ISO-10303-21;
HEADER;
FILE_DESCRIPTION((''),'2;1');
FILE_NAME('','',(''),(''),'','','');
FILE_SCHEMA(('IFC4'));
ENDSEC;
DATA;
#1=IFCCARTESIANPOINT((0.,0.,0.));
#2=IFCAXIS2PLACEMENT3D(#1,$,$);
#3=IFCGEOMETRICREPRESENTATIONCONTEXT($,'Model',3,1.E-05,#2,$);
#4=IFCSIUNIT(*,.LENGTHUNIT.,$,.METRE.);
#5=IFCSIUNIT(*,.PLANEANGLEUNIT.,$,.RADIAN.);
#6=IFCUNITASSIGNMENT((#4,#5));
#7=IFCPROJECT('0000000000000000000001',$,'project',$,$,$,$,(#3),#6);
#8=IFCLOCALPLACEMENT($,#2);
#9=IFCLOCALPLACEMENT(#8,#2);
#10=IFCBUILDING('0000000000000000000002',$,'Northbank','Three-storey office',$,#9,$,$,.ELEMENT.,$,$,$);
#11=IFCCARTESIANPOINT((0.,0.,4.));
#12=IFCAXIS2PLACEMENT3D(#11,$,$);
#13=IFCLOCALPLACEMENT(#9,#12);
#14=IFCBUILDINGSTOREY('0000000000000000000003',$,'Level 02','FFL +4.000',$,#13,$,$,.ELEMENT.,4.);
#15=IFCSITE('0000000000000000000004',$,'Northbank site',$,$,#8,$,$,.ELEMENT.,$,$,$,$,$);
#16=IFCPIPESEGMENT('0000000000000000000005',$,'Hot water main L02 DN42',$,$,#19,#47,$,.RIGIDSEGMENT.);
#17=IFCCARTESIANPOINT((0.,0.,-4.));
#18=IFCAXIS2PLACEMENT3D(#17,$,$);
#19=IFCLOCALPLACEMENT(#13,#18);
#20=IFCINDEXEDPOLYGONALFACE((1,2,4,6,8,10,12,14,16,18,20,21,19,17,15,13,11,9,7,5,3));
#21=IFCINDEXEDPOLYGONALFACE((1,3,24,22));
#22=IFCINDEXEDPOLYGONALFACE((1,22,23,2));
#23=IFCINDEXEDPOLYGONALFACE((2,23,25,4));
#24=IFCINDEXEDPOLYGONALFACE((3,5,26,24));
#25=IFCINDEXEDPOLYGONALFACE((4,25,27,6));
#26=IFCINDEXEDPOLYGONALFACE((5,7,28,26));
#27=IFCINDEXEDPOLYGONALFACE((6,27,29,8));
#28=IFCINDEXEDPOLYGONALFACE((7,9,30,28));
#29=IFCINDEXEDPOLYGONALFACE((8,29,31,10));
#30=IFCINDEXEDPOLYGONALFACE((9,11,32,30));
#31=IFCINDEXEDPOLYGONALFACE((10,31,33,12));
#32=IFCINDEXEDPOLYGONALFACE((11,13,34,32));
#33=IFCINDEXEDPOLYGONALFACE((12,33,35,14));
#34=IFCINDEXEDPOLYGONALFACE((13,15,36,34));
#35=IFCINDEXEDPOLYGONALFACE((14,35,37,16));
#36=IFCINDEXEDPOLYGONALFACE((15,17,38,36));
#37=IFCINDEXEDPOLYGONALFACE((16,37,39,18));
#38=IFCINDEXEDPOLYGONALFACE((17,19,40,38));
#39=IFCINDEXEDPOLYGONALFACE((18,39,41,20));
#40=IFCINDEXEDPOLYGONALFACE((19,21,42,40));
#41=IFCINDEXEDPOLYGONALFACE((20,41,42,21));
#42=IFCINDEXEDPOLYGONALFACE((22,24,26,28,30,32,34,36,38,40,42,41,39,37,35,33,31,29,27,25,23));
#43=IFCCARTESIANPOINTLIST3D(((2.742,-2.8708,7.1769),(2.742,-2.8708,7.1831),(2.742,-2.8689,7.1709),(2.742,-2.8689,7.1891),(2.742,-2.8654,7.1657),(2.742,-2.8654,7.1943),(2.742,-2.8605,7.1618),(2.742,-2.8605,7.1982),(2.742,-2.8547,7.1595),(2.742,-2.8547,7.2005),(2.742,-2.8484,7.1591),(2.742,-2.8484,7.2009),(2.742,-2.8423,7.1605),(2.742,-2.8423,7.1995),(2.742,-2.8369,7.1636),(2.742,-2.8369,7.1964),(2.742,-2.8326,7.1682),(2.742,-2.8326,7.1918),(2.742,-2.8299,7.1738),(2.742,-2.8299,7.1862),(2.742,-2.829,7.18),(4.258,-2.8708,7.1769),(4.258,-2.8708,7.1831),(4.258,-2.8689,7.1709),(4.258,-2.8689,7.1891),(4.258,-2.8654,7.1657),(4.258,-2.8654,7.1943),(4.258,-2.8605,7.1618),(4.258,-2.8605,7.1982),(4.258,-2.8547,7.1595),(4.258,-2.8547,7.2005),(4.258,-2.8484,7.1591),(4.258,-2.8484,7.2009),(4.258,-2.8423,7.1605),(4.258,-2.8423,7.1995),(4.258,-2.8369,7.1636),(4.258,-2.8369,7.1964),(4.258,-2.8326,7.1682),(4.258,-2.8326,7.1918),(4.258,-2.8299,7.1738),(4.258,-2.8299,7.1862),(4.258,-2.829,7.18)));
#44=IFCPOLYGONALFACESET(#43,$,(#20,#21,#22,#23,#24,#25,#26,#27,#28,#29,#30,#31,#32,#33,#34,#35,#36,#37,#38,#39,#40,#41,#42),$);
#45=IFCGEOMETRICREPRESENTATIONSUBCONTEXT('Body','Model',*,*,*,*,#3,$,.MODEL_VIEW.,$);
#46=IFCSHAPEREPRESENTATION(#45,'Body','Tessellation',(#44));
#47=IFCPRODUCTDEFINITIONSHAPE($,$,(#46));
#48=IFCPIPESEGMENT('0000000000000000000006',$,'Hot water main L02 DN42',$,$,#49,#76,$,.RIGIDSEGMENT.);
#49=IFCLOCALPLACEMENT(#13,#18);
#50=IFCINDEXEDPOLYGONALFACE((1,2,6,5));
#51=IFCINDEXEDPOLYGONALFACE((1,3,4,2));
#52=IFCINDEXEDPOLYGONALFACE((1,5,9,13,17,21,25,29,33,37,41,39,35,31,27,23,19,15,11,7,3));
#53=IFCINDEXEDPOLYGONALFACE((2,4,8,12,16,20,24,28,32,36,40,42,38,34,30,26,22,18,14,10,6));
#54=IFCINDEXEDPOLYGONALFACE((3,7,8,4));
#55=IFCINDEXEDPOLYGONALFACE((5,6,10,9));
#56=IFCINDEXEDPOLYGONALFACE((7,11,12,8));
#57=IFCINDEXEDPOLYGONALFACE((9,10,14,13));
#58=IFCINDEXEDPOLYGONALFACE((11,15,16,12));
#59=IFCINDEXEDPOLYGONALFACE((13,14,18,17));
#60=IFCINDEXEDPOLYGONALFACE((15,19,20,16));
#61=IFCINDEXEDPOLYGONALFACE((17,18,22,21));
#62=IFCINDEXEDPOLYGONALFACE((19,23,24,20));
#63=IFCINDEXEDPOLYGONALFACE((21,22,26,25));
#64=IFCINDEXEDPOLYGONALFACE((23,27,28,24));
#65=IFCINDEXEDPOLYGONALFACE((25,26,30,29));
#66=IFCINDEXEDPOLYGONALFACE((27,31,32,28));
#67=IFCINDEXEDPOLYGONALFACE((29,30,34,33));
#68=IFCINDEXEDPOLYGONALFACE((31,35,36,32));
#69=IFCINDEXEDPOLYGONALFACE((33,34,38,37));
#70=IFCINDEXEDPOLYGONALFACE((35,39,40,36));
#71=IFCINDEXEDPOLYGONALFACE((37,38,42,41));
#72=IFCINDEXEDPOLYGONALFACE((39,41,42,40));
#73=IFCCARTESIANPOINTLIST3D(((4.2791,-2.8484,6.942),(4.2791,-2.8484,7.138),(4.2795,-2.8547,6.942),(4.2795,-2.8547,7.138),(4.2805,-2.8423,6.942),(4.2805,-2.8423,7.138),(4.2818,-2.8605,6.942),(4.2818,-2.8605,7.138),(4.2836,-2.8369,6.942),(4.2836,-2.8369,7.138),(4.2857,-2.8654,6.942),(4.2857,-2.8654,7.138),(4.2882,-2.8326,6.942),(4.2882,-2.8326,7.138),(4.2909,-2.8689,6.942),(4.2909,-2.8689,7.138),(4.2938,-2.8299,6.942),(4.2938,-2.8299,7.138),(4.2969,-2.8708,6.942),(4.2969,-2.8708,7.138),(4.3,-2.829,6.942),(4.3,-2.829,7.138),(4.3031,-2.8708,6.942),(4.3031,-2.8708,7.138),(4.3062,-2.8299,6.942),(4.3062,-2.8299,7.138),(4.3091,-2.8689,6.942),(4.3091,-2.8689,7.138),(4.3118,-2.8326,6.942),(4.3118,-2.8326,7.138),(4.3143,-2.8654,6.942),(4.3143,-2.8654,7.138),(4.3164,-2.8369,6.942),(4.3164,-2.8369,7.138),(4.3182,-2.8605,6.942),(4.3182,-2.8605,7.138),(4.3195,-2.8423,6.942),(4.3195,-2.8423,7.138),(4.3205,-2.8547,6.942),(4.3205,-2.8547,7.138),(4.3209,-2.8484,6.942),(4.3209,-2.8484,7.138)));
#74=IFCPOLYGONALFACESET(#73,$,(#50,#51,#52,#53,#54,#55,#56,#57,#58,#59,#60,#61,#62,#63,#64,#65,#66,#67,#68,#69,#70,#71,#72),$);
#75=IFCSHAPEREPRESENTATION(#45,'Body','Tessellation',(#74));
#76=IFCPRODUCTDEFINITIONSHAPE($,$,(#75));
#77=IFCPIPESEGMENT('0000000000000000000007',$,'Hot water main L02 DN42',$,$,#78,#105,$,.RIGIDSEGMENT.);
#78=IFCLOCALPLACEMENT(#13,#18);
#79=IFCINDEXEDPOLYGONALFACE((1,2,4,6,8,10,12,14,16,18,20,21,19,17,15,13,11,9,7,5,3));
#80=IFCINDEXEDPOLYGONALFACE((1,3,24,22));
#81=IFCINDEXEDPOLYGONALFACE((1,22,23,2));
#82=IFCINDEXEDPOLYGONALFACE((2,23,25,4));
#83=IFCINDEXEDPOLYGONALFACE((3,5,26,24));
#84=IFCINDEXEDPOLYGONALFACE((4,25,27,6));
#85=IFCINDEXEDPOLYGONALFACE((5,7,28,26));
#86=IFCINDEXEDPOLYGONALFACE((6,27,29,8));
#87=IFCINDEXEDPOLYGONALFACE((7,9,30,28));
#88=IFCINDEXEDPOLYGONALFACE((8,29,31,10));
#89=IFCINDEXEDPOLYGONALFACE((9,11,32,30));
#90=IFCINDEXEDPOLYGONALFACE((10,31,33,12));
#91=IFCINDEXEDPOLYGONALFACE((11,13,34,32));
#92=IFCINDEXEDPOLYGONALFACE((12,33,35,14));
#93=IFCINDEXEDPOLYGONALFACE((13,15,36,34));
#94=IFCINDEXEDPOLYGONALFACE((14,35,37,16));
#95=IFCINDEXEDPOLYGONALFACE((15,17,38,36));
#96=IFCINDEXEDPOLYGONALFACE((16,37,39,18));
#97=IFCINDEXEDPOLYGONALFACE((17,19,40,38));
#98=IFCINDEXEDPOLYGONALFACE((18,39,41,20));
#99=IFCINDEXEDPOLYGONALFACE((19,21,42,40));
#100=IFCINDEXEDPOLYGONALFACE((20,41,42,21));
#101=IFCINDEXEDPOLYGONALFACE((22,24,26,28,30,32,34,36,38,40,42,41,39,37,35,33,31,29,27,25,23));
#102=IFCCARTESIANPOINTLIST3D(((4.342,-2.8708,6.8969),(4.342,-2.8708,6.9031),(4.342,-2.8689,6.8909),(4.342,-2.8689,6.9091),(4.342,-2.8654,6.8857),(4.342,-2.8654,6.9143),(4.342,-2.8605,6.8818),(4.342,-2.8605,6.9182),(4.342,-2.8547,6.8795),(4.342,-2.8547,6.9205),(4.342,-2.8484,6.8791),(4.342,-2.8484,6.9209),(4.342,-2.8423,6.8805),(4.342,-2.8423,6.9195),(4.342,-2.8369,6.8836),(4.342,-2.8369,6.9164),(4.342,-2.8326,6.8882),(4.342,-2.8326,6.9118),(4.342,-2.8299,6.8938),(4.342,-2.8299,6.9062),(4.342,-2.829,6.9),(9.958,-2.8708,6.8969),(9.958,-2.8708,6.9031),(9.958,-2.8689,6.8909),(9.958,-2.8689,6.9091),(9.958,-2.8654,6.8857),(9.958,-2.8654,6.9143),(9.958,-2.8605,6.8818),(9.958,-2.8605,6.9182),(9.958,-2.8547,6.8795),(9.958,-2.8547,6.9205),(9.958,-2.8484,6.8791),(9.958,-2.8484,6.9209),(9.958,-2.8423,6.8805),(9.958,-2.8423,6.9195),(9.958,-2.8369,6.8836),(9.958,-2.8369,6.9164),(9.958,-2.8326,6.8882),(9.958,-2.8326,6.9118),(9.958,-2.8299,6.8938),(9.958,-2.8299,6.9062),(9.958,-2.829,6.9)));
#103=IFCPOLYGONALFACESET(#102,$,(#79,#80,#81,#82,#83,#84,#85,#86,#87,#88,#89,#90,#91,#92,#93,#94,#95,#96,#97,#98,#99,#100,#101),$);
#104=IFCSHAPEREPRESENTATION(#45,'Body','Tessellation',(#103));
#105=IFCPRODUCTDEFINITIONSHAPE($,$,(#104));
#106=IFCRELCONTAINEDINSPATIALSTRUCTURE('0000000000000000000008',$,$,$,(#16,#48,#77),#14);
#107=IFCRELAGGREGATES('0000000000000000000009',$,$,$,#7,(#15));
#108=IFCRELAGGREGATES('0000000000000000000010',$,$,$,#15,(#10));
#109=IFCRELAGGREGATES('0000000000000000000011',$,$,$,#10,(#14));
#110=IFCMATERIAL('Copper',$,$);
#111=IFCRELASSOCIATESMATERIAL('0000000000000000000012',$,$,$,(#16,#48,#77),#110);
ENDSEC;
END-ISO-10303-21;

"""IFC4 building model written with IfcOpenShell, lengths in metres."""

from ifc_helpers import new_model, si_unit, frame, origin, place, context, subcontext, project, spatial, circle, extrude, material, element, save


model = new_model("IFC4")

# Units and contexts
model_context = context("Model", 3, precision=1e-05, world=origin())
body_context = subcontext(model_context, "Body", "Model", "MODEL_VIEW")
ifc_project = project(units=[si_unit("LENGTHUNIT", "METRE"), si_unit("PLANEANGLEUNIT", "RADIAN")], contexts=[model_context])

# Site, building, storey
site_placement = place(None, origin())
site = spatial("IfcSite", under=ifc_project, at=site_placement, Name="Northbank site", CompositionType="ELEMENT")
building_placement = place(site_placement, origin())
building = spatial("IfcBuilding", under=site, at=building_placement, Name="Northbank", Description="Three-storey office", CompositionType="ELEMENT")
storey_placement = place(building_placement, frame((0.0, 0.0, 4.0)))
storey = spatial("IfcBuildingStorey", under=building, at=storey_placement, Name="Level 02", Description="FFL +4.000", CompositionType="ELEMENT", Elevation=4.0)

# Shared definitions
ifc_material = material(Name="Copper")

# Pipe segments
pipe_segment_1_placement = place(storey_placement, frame((0.0, 0.0, -4.0)))
element("IfcPipeSegment", 1, at=pipe_segment_1_placement, inside=storey, material=ifc_material, Name="Hot water main L02 DN42", PredefinedType="RIGIDSEGMENT", context=body_context, shape_type="SweptSolid", body=[
    extrude(circle(Radius=0.021), frame((2.742, -2.85, 7.18), z_axis=(1.0, 0.0, 0.0), x_axis=(0.0, 1.0, 0.0)), (0.0, 0.0, 1.0), 1.516),
])
pipe_segment_2_placement = place(storey_placement, frame((0.0, 0.0, -4.0)))
element("IfcPipeSegment", 2, at=pipe_segment_2_placement, inside=storey, material=ifc_material, Name="Hot water main L02 DN42", PredefinedType="RIGIDSEGMENT", context=body_context, shape_type="SweptSolid", body=[
    extrude(circle(Radius=0.021), frame((4.3, -2.85, 7.138), z_axis=(0.0, 0.0, -1.0), x_axis=(0.0, 1.0, 0.0)), (0.0, 0.0, 1.0), 0.196),
])
pipe_segment_3_placement = place(storey_placement, frame((0.0, 0.0, -4.0)))
element("IfcPipeSegment", 3, at=pipe_segment_3_placement, inside=storey, material=ifc_material, Name="Hot water main L02 DN42", PredefinedType="RIGIDSEGMENT", context=body_context, shape_type="SweptSolid", body=[
    extrude(circle(Radius=0.021), frame((4.342, -2.85, 6.9), z_axis=(1.0, 0.0, 0.0), x_axis=(0.0, 1.0, 0.0)), (0.0, 0.0, 1.0), 5.616),
])

save(model, "model.ifc")
